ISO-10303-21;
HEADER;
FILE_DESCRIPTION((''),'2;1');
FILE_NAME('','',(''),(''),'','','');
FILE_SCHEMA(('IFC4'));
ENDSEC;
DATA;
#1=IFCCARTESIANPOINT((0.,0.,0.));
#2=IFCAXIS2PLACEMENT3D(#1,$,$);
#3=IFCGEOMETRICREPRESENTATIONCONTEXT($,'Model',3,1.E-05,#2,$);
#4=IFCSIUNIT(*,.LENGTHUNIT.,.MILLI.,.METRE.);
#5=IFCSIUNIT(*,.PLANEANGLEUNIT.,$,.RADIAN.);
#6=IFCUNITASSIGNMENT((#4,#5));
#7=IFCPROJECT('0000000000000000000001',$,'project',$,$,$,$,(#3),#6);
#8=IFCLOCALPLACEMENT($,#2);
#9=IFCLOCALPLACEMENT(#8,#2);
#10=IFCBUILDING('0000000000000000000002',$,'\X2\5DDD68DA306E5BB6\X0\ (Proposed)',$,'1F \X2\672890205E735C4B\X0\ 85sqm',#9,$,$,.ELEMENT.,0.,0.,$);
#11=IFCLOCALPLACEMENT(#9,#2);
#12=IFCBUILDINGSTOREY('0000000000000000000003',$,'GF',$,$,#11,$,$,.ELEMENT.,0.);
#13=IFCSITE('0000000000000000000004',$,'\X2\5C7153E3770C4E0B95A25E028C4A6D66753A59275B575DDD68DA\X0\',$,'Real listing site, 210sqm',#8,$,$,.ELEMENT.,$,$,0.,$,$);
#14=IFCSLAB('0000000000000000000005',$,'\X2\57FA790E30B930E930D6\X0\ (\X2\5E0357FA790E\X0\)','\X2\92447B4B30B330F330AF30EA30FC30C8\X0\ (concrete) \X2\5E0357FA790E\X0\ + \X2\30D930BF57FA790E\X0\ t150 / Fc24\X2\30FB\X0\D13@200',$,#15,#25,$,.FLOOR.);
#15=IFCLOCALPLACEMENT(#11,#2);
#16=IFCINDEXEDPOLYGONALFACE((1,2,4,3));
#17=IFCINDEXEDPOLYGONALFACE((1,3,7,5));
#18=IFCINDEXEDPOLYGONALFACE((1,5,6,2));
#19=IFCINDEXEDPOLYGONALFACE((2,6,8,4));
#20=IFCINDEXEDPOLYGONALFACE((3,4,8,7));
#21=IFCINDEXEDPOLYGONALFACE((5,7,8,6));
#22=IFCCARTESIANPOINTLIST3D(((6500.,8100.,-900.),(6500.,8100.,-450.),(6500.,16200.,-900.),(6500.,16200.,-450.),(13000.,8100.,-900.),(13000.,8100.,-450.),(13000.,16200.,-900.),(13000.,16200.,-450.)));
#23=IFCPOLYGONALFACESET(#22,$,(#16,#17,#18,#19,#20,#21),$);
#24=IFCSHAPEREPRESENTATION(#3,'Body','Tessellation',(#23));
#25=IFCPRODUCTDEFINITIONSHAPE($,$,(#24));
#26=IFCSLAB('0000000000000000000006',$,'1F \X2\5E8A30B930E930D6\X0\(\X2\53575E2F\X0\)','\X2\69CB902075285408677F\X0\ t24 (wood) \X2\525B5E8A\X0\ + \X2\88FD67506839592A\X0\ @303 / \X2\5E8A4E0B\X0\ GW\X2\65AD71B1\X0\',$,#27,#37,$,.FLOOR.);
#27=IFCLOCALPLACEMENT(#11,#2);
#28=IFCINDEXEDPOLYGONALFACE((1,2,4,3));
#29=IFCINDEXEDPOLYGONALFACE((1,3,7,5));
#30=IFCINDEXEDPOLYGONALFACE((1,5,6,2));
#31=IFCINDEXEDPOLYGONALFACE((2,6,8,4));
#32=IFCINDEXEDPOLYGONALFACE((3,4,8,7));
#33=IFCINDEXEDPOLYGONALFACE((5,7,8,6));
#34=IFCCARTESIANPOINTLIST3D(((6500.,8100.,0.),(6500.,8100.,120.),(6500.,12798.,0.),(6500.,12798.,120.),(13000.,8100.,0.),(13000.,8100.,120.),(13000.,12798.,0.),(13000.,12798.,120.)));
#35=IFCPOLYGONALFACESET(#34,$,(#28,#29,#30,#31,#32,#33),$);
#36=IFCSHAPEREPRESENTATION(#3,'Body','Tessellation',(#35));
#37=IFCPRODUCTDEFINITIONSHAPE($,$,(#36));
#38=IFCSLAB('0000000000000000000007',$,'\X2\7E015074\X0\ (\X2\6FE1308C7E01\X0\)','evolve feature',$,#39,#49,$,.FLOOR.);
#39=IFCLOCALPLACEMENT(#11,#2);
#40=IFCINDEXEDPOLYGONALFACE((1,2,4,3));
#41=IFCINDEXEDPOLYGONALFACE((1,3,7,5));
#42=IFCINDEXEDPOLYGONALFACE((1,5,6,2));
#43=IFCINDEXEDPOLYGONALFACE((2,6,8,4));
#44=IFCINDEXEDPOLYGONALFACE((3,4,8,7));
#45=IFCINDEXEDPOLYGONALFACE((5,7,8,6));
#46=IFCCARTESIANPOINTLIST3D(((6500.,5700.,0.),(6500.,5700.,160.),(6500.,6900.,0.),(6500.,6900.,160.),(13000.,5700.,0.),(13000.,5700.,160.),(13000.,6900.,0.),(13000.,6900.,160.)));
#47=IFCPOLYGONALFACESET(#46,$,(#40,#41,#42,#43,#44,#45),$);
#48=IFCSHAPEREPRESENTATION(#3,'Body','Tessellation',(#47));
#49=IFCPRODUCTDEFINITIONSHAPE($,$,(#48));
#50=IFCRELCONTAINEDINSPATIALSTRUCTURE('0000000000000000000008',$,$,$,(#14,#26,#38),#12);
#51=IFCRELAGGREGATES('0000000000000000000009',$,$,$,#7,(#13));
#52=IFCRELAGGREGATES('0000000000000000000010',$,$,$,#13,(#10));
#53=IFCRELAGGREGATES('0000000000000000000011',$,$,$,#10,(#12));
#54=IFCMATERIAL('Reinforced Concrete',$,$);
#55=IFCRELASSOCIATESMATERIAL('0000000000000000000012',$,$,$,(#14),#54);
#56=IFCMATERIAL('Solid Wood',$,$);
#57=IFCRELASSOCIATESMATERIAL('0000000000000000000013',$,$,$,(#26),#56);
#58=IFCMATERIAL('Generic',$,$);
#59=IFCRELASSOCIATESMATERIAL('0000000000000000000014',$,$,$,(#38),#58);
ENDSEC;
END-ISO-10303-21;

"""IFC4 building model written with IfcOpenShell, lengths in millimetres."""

from ifc_helpers import new_model, si_unit, frame, frame_2d, origin, place, context, project, spatial, rectangle, extrude, material, element, save


model = new_model("IFC4")

# Units and contexts
model_context = context("Model", 3, precision=1e-05, world=origin())
ifc_project = project(units=[si_unit("LENGTHUNIT", "METRE", prefix="MILLI"), si_unit("PLANEANGLEUNIT", "RADIAN")], contexts=[model_context])

# Site, building, storey
site_placement = place(None, origin())
site = spatial("IfcSite", under=ifc_project, at=site_placement, Name="山口県下関市豊浦町大字川棚", ObjectType="Real listing site, 210sqm", CompositionType="ELEMENT", RefElevation=0.0)
building_placement = place(site_placement, origin())
building = spatial("IfcBuilding", under=site, at=building_placement, Name="川棚の家 (Proposed)", ObjectType="1F 木造平屋 85sqm", CompositionType="ELEMENT", ElevationOfRefHeight=0.0, ElevationOfTerrain=0.0)
storey_placement = place(building_placement, origin())
storey = spatial("IfcBuildingStorey", under=building, at=storey_placement, Name="GF", CompositionType="ELEMENT", Elevation=0.0)

# Slabs
ifc_material_1 = material(Name="Reinforced Concrete")
slab_1_placement = place(storey_placement, frame((3250.0, 4050.0, -450.0)))
element("IfcSlab", 1, at=slab_1_placement, inside=storey, material=ifc_material_1, Name="基礎スラブ (布基礎)", Description="鉄筋コンクリート (concrete) 布基礎 + ベタ基礎 t150 / Fc24・D13@200", PredefinedType="FLOOR", context=model_context, shape_type="SweptSolid", body=[
    extrude(rectangle(XDim=6500.0, YDim=8100.0, at=frame_2d((3250.0, 4050.0))), frame((3250.0, 4050.0, -450.0)), (0.0, 0.0, 1.0), 450.0),
])
ifc_material_2 = material(Name="Solid Wood")
slab_2_placement = place(storey_placement, frame((3250.0, 4050.0, 0.0)))
element("IfcSlab", 2, at=slab_2_placement, inside=storey, material=ifc_material_2, Name="1F 床スラブ(南帯)", Description="構造用合板 t24 (wood) 剛床 + 製材根太 @303 / 床下 GW断熱", PredefinedType="FLOOR", context=model_context, shape_type="SweptSolid", body=[
    extrude(rectangle(XDim=6500.0, YDim=4698.0, at=frame_2d((3250.0, 2349.0))), frame((3250.0, 4050.0, 0.0)), (0.0, 0.0, 1.0), 120.0),
])
ifc_material_3 = material(Name="Generic")
slab_3_placement = place(storey_placement, frame((3250.0, 2850.0, 0.0)))
element("IfcSlab", 3, at=slab_3_placement, inside=storey, material=ifc_material_3, Name="縁側 (濡れ縁)", Description="evolve feature", PredefinedType="FLOOR", context=model_context, shape_type="SweptSolid", body=[
    extrude(rectangle(XDim=6500.0, YDim=1200.0, at=frame_2d((3250.0, 600.0))), frame((3250.0, 2850.0, 0.0)), (0.0, 0.0, 1.0), 160.0),
])

save(model, "model.ifc")
